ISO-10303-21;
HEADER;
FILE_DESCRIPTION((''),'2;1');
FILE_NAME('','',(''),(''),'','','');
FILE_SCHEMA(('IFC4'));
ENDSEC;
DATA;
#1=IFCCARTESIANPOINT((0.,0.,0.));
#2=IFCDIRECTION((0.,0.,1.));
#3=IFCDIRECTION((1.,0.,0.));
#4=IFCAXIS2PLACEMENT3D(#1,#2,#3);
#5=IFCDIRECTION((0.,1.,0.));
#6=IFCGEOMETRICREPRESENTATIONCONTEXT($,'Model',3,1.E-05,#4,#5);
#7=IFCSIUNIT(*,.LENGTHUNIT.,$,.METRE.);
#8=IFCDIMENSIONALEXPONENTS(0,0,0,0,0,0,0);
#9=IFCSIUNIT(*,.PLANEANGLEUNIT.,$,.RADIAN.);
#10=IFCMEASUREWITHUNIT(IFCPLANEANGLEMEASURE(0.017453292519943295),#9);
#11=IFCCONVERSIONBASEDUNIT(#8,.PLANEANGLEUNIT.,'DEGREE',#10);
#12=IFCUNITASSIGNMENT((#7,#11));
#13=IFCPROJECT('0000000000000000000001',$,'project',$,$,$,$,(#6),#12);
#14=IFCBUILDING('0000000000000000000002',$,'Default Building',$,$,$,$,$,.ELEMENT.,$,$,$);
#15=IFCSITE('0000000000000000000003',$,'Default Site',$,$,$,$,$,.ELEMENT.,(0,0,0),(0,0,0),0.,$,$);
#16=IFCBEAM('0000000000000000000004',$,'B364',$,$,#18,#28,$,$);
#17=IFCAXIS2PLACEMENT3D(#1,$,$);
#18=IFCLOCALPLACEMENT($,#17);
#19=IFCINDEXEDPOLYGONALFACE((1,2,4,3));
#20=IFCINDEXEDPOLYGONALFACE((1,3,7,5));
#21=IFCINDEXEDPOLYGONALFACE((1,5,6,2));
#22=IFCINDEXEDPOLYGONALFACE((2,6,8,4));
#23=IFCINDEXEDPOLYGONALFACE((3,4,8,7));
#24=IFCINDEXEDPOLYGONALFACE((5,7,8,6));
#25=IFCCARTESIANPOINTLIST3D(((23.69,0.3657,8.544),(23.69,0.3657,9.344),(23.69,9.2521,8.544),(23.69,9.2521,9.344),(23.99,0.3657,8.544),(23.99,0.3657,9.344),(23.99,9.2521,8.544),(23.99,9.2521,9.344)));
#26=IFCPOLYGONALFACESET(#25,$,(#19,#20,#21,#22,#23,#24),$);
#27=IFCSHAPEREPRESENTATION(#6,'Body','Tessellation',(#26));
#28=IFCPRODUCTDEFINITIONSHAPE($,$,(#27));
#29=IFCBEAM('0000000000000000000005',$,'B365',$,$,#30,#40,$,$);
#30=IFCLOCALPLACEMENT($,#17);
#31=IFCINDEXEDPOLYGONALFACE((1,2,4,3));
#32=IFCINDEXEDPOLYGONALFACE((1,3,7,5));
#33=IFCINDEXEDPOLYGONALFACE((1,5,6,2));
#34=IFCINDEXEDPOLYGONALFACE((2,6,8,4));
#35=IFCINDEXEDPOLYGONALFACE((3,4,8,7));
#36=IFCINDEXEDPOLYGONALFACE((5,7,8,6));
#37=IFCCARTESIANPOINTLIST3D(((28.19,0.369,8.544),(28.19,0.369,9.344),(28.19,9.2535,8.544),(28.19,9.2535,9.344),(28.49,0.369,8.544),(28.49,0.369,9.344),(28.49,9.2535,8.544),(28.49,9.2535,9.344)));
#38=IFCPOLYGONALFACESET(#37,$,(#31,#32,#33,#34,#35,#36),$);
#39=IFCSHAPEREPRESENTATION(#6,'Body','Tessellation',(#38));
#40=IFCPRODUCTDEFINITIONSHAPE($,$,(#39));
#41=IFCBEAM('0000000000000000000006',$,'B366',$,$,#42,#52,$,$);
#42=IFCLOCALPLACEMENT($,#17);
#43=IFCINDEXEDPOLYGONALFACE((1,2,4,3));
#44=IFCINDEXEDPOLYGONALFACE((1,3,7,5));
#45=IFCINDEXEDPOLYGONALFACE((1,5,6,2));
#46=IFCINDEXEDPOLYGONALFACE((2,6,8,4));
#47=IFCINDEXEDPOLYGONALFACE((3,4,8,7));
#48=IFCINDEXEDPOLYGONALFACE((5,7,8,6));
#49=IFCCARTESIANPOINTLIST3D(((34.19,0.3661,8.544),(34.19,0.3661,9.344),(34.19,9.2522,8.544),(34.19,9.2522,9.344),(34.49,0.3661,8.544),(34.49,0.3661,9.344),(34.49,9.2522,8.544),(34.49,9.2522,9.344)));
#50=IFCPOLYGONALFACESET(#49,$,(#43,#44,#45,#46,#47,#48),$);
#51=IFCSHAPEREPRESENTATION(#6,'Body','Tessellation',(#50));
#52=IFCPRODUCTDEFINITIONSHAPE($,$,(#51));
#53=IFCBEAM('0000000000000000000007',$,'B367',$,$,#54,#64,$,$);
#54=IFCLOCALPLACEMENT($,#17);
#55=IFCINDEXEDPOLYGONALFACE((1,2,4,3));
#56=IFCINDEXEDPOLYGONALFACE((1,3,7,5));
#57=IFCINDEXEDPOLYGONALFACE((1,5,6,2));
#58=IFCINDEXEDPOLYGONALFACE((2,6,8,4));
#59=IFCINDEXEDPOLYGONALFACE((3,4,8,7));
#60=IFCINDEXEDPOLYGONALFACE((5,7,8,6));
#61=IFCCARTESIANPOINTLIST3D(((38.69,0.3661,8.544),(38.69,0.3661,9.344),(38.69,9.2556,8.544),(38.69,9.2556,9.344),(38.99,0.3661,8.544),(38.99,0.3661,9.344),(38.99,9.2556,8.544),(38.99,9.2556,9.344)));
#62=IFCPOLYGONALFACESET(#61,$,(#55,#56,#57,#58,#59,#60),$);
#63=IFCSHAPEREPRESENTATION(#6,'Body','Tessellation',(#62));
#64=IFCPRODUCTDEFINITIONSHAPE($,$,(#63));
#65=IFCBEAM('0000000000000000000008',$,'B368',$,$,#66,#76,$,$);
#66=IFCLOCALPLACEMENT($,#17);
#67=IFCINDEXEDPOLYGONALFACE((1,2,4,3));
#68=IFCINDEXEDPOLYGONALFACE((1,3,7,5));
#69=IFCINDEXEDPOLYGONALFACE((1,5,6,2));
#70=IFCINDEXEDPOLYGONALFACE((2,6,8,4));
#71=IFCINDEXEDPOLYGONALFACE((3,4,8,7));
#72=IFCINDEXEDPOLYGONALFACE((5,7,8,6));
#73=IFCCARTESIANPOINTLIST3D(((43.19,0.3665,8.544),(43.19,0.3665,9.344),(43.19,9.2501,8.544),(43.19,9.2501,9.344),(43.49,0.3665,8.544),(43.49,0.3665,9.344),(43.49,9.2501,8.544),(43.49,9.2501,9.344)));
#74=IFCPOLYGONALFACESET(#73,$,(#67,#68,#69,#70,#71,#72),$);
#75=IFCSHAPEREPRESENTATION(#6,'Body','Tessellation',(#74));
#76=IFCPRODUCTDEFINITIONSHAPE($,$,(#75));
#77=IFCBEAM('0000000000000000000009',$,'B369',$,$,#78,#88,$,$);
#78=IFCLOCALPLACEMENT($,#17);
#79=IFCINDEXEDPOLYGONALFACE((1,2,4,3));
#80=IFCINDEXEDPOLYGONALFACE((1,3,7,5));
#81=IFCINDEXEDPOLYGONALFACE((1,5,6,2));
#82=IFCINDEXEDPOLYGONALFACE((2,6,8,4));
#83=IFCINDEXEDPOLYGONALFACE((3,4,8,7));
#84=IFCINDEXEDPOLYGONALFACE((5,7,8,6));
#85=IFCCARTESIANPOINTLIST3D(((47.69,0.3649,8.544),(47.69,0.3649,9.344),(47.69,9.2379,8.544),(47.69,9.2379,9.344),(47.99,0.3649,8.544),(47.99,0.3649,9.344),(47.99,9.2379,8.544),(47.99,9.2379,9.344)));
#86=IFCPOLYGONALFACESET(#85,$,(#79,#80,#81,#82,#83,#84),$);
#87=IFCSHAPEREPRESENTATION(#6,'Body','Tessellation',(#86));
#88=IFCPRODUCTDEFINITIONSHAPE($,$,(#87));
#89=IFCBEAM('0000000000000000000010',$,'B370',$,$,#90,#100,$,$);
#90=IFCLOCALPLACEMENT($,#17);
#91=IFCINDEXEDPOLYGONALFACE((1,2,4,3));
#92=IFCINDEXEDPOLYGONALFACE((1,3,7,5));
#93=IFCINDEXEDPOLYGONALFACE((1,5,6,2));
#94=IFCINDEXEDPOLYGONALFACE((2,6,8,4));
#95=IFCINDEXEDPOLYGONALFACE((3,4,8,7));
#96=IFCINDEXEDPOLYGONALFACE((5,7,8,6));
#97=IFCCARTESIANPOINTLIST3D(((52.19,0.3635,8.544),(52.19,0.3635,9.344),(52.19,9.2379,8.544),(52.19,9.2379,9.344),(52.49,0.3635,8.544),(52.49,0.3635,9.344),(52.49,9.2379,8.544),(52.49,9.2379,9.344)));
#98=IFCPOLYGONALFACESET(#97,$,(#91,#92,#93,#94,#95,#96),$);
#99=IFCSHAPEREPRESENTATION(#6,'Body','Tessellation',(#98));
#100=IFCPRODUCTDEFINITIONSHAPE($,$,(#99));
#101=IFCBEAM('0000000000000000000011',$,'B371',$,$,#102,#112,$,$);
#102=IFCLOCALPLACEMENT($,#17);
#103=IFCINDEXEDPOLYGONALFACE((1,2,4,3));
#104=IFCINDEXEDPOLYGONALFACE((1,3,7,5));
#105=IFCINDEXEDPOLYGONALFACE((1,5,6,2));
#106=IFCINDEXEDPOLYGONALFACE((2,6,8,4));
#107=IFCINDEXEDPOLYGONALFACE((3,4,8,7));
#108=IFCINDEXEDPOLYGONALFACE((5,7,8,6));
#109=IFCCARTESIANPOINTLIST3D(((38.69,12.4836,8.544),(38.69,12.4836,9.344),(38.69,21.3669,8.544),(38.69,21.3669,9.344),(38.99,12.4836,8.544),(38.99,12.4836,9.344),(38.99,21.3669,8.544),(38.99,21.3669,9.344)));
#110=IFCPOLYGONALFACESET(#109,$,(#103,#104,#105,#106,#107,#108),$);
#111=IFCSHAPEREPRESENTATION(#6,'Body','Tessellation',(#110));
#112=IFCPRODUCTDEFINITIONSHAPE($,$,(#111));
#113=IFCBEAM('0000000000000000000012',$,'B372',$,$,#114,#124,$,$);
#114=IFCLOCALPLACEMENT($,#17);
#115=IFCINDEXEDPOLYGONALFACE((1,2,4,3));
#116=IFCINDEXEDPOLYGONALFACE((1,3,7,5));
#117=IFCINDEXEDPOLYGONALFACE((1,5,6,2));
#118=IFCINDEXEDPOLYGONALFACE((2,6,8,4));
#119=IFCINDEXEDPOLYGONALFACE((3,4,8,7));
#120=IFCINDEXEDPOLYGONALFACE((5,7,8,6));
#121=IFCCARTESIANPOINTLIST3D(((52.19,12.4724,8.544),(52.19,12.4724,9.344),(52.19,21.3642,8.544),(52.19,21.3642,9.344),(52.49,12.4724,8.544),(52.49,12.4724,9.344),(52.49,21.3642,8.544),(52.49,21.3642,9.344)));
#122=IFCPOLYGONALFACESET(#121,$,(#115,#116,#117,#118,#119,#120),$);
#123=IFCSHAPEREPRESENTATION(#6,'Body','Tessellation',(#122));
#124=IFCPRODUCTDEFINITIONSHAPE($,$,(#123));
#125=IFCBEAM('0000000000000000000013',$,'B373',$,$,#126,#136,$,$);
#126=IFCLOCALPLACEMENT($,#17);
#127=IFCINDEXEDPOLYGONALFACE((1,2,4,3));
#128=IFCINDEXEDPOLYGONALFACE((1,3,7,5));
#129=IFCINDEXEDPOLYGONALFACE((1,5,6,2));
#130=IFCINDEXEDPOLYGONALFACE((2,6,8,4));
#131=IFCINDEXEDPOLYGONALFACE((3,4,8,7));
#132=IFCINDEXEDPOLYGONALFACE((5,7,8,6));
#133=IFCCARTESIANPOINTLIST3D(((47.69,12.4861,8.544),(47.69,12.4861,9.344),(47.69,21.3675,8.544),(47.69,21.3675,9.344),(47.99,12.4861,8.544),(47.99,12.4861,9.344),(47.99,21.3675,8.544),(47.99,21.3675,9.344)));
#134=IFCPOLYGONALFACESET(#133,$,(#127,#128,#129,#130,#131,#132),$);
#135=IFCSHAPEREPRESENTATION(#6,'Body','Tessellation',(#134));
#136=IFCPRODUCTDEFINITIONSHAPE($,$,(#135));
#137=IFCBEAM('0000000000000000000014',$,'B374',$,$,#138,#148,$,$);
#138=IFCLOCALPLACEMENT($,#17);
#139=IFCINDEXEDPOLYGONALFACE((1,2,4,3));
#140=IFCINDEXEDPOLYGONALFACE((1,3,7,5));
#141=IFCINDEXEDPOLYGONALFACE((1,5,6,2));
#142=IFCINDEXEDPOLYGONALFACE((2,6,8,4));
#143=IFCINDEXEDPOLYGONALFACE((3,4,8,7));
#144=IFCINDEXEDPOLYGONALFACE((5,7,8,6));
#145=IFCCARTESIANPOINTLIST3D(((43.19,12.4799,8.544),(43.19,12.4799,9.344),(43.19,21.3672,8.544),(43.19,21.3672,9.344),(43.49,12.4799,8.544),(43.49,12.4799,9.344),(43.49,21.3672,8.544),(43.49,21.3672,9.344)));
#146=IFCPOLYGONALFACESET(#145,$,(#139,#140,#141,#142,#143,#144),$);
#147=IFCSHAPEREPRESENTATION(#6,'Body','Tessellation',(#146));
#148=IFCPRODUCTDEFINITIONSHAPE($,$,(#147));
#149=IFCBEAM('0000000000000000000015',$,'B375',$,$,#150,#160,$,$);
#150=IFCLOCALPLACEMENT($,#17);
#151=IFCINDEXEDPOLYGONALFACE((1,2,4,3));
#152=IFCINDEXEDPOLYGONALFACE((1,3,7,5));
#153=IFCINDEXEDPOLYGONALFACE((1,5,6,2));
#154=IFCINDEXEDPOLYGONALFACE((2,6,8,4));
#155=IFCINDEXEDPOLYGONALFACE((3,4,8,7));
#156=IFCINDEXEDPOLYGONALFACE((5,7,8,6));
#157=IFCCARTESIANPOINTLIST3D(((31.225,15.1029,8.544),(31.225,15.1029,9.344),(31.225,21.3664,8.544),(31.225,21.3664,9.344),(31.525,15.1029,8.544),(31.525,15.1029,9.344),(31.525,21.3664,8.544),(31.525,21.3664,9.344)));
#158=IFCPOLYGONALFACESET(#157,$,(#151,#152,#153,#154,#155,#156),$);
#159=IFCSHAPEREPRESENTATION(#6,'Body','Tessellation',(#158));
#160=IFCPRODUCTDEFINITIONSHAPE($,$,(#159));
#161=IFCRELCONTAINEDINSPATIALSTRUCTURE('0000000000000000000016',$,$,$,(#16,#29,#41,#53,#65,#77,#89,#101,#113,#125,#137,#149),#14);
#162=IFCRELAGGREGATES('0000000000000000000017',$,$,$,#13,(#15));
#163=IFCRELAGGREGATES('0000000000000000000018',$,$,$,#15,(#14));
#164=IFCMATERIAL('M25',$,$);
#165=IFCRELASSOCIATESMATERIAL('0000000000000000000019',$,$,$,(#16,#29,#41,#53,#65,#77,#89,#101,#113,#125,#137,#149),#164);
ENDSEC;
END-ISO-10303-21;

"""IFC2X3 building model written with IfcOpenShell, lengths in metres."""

from ifc_helpers import new_model, entity, si_unit, converted_unit, direction, frame, frame_2d, origin_with_axes, place, context, project, spatial, rectangle, extrude, material, element, save


model = new_model("IFC2X3")

# Units and contexts
model_context = context("Model", 3, precision=1e-05, world=origin_with_axes(), true_north=direction((0.0, 1.0, 0.0)))
ifc_project = project(units=[si_unit("LENGTHUNIT", "METRE"), converted_unit("PLANEANGLEUNIT", "DEGREE", entity("IfcPlaneAngleMeasure", 0.017453292519943295), si_unit("PLANEANGLEUNIT", "RADIAN"), dimensions=[0, 0, 0, 0, 0, 0, 0])], contexts=[model_context])

# Site, building
site = spatial("IfcSite", under=ifc_project, Name="Default Site", CompositionType="ELEMENT", RefLatitude=(0, 0, 0), RefLongitude=(0, 0, 0), RefElevation=0.0)
building = spatial("IfcBuilding", under=site, Name="Default Building", CompositionType="ELEMENT")

# Beams
ifc_material = material(Name="M25")
placement = place(None, origin_with_axes())
element("IfcBeam", 1, at=placement, inside=building, material=ifc_material, Name="B364", context=model_context, shape_type="SweptSolid", body=[
    extrude(rectangle(XDim=0.3, YDim=0.8, at=frame_2d((0.0, 0.0), x_axis=(0.0, 1.0, 0.0))), frame((23.84, 0.3657, 8.944), z_axis=(0.0, 1.0, 0.0), x_axis=(0.0, 0.0, -1.0)), (0.0, 0.0, 1.0), 8.8864),
])
element("IfcBeam", 2, at=placement, inside=building, material=ifc_material, Name="B365", context=model_context, shape_type="SweptSolid", body=[
    extrude(rectangle(XDim=0.3, YDim=0.8, at=frame_2d((0.0, 0.0), x_axis=(0.0, 1.0, 0.0))), frame((28.34, 0.369, 8.944), z_axis=(0.0, 1.0, 0.0), x_axis=(0.0, 0.0, -1.0)), (0.0, 0.0, 1.0), 8.8845),
])
element("IfcBeam", 3, at=placement, inside=building, material=ifc_material, Name="B366", context=model_context, shape_type="SweptSolid", body=[
    extrude(rectangle(XDim=0.3, YDim=0.8, at=frame_2d((0.0, 0.0), x_axis=(0.0, 1.0, 0.0))), frame((34.34, 0.3661, 8.944), z_axis=(0.0, 1.0, 0.0), x_axis=(0.0, 0.0, -1.0)), (0.0, 0.0, 1.0), 8.8861),
])
element("IfcBeam", 4, at=placement, inside=building, material=ifc_material, Name="B367", context=model_context, shape_type="SweptSolid", body=[
    extrude(rectangle(XDim=0.3, YDim=0.8, at=frame_2d((0.0, 0.0), x_axis=(0.0, 1.0, 0.0))), frame((38.84, 0.3661, 8.944), z_axis=(0.0, 1.0, 0.0), x_axis=(0.0, 0.0, -1.0)), (0.0, 0.0, 1.0), 8.8895),
])
element("IfcBeam", 5, at=placement, inside=building, material=ifc_material, Name="B368", context=model_context, shape_type="SweptSolid", body=[
    extrude(rectangle(XDim=0.3, YDim=0.8, at=frame_2d((0.0, 0.0), x_axis=(0.0, 1.0, 0.0))), frame((43.34, 0.3665, 8.944), z_axis=(0.0, 1.0, 0.0), x_axis=(0.0, 0.0, -1.0)), (0.0, 0.0, 1.0), 8.8836),
])
element("IfcBeam", 6, at=placement, inside=building, material=ifc_material, Name="B369", context=model_context, shape_type="SweptSolid", body=[
    extrude(rectangle(XDim=0.3, YDim=0.8, at=frame_2d((0.0, 0.0), x_axis=(0.0, 1.0, 0.0))), frame((47.84, 0.3649, 8.944), z_axis=(0.0, 1.0, 0.0), x_axis=(0.0, 0.0, -1.0)), (0.0, 0.0, 1.0), 8.873),
])
element("IfcBeam", 7, at=placement, inside=building, material=ifc_material, Name="B370", context=model_context, shape_type="SweptSolid", body=[
    extrude(rectangle(XDim=0.3, YDim=0.8, at=frame_2d((0.0, 0.0), x_axis=(0.0, 1.0, 0.0))), frame((52.34, 0.3635, 8.944), z_axis=(0.0, 1.0, 0.0), x_axis=(0.0, 0.0, -1.0)), (0.0, 0.0, 1.0), 8.8744),
])
element("IfcBeam", 8, at=placement, inside=building, material=ifc_material, Name="B371", context=model_context, shape_type="SweptSolid", body=[
    extrude(rectangle(XDim=0.3, YDim=0.8, at=frame_2d((0.0, 0.0), x_axis=(0.0, 1.0, 0.0))), frame((38.84, 21.3669, 8.944), z_axis=(0.0, -1.0, 0.0), x_axis=(0.0, 0.0, -1.0)), (0.0, 0.0, 1.0), 8.8833),
])
element("IfcBeam", 9, at=placement, inside=building, material=ifc_material, Name="B372", context=model_context, shape_type="SweptSolid", body=[
    extrude(rectangle(XDim=0.3, YDim=0.8, at=frame_2d((0.0, 0.0), x_axis=(0.0, 1.0, 0.0))), frame((52.34, 12.4724, 8.944), z_axis=(0.0, 1.0, 0.0), x_axis=(0.0, 0.0, -1.0)), (0.0, 0.0, 1.0), 8.8918),
])
element("IfcBeam", 10, at=placement, inside=building, material=ifc_material, Name="B373", context=model_context, shape_type="SweptSolid", body=[
    extrude(rectangle(XDim=0.3, YDim=0.8, at=frame_2d((0.0, 0.0), x_axis=(0.0, 1.0, 0.0))), frame((47.84, 12.4861, 8.944), z_axis=(0.0, 1.0, 0.0), x_axis=(0.0, 0.0, -1.0)), (0.0, 0.0, 1.0), 8.8814),
])
element("IfcBeam", 11, at=placement, inside=building, material=ifc_material, Name="B374", context=model_context, shape_type="SweptSolid", body=[
    extrude(rectangle(XDim=0.3, YDim=0.8, at=frame_2d((0.0, 0.0), x_axis=(0.0, 1.0, 0.0))), frame((43.34, 21.3672, 8.944), z_axis=(0.0, -1.0, 0.0), x_axis=(0.0, 0.0, -1.0)), (0.0, 0.0, 1.0), 8.8873),
])
element("IfcBeam", 12, at=placement, inside=building, material=ifc_material, Name="B375", context=model_context, shape_type="SweptSolid", body=[
    extrude(rectangle(XDim=0.3, YDim=0.8, at=frame_2d((0.0, 0.0), x_axis=(0.0, 1.0, 0.0))), frame((31.375, 21.3664, 8.944), z_axis=(0.0, -1.0, 0.0), x_axis=(0.0, 0.0, -1.0)), (0.0, 0.0, 1.0), 6.2635),
])

save(model, "model.ifc")
